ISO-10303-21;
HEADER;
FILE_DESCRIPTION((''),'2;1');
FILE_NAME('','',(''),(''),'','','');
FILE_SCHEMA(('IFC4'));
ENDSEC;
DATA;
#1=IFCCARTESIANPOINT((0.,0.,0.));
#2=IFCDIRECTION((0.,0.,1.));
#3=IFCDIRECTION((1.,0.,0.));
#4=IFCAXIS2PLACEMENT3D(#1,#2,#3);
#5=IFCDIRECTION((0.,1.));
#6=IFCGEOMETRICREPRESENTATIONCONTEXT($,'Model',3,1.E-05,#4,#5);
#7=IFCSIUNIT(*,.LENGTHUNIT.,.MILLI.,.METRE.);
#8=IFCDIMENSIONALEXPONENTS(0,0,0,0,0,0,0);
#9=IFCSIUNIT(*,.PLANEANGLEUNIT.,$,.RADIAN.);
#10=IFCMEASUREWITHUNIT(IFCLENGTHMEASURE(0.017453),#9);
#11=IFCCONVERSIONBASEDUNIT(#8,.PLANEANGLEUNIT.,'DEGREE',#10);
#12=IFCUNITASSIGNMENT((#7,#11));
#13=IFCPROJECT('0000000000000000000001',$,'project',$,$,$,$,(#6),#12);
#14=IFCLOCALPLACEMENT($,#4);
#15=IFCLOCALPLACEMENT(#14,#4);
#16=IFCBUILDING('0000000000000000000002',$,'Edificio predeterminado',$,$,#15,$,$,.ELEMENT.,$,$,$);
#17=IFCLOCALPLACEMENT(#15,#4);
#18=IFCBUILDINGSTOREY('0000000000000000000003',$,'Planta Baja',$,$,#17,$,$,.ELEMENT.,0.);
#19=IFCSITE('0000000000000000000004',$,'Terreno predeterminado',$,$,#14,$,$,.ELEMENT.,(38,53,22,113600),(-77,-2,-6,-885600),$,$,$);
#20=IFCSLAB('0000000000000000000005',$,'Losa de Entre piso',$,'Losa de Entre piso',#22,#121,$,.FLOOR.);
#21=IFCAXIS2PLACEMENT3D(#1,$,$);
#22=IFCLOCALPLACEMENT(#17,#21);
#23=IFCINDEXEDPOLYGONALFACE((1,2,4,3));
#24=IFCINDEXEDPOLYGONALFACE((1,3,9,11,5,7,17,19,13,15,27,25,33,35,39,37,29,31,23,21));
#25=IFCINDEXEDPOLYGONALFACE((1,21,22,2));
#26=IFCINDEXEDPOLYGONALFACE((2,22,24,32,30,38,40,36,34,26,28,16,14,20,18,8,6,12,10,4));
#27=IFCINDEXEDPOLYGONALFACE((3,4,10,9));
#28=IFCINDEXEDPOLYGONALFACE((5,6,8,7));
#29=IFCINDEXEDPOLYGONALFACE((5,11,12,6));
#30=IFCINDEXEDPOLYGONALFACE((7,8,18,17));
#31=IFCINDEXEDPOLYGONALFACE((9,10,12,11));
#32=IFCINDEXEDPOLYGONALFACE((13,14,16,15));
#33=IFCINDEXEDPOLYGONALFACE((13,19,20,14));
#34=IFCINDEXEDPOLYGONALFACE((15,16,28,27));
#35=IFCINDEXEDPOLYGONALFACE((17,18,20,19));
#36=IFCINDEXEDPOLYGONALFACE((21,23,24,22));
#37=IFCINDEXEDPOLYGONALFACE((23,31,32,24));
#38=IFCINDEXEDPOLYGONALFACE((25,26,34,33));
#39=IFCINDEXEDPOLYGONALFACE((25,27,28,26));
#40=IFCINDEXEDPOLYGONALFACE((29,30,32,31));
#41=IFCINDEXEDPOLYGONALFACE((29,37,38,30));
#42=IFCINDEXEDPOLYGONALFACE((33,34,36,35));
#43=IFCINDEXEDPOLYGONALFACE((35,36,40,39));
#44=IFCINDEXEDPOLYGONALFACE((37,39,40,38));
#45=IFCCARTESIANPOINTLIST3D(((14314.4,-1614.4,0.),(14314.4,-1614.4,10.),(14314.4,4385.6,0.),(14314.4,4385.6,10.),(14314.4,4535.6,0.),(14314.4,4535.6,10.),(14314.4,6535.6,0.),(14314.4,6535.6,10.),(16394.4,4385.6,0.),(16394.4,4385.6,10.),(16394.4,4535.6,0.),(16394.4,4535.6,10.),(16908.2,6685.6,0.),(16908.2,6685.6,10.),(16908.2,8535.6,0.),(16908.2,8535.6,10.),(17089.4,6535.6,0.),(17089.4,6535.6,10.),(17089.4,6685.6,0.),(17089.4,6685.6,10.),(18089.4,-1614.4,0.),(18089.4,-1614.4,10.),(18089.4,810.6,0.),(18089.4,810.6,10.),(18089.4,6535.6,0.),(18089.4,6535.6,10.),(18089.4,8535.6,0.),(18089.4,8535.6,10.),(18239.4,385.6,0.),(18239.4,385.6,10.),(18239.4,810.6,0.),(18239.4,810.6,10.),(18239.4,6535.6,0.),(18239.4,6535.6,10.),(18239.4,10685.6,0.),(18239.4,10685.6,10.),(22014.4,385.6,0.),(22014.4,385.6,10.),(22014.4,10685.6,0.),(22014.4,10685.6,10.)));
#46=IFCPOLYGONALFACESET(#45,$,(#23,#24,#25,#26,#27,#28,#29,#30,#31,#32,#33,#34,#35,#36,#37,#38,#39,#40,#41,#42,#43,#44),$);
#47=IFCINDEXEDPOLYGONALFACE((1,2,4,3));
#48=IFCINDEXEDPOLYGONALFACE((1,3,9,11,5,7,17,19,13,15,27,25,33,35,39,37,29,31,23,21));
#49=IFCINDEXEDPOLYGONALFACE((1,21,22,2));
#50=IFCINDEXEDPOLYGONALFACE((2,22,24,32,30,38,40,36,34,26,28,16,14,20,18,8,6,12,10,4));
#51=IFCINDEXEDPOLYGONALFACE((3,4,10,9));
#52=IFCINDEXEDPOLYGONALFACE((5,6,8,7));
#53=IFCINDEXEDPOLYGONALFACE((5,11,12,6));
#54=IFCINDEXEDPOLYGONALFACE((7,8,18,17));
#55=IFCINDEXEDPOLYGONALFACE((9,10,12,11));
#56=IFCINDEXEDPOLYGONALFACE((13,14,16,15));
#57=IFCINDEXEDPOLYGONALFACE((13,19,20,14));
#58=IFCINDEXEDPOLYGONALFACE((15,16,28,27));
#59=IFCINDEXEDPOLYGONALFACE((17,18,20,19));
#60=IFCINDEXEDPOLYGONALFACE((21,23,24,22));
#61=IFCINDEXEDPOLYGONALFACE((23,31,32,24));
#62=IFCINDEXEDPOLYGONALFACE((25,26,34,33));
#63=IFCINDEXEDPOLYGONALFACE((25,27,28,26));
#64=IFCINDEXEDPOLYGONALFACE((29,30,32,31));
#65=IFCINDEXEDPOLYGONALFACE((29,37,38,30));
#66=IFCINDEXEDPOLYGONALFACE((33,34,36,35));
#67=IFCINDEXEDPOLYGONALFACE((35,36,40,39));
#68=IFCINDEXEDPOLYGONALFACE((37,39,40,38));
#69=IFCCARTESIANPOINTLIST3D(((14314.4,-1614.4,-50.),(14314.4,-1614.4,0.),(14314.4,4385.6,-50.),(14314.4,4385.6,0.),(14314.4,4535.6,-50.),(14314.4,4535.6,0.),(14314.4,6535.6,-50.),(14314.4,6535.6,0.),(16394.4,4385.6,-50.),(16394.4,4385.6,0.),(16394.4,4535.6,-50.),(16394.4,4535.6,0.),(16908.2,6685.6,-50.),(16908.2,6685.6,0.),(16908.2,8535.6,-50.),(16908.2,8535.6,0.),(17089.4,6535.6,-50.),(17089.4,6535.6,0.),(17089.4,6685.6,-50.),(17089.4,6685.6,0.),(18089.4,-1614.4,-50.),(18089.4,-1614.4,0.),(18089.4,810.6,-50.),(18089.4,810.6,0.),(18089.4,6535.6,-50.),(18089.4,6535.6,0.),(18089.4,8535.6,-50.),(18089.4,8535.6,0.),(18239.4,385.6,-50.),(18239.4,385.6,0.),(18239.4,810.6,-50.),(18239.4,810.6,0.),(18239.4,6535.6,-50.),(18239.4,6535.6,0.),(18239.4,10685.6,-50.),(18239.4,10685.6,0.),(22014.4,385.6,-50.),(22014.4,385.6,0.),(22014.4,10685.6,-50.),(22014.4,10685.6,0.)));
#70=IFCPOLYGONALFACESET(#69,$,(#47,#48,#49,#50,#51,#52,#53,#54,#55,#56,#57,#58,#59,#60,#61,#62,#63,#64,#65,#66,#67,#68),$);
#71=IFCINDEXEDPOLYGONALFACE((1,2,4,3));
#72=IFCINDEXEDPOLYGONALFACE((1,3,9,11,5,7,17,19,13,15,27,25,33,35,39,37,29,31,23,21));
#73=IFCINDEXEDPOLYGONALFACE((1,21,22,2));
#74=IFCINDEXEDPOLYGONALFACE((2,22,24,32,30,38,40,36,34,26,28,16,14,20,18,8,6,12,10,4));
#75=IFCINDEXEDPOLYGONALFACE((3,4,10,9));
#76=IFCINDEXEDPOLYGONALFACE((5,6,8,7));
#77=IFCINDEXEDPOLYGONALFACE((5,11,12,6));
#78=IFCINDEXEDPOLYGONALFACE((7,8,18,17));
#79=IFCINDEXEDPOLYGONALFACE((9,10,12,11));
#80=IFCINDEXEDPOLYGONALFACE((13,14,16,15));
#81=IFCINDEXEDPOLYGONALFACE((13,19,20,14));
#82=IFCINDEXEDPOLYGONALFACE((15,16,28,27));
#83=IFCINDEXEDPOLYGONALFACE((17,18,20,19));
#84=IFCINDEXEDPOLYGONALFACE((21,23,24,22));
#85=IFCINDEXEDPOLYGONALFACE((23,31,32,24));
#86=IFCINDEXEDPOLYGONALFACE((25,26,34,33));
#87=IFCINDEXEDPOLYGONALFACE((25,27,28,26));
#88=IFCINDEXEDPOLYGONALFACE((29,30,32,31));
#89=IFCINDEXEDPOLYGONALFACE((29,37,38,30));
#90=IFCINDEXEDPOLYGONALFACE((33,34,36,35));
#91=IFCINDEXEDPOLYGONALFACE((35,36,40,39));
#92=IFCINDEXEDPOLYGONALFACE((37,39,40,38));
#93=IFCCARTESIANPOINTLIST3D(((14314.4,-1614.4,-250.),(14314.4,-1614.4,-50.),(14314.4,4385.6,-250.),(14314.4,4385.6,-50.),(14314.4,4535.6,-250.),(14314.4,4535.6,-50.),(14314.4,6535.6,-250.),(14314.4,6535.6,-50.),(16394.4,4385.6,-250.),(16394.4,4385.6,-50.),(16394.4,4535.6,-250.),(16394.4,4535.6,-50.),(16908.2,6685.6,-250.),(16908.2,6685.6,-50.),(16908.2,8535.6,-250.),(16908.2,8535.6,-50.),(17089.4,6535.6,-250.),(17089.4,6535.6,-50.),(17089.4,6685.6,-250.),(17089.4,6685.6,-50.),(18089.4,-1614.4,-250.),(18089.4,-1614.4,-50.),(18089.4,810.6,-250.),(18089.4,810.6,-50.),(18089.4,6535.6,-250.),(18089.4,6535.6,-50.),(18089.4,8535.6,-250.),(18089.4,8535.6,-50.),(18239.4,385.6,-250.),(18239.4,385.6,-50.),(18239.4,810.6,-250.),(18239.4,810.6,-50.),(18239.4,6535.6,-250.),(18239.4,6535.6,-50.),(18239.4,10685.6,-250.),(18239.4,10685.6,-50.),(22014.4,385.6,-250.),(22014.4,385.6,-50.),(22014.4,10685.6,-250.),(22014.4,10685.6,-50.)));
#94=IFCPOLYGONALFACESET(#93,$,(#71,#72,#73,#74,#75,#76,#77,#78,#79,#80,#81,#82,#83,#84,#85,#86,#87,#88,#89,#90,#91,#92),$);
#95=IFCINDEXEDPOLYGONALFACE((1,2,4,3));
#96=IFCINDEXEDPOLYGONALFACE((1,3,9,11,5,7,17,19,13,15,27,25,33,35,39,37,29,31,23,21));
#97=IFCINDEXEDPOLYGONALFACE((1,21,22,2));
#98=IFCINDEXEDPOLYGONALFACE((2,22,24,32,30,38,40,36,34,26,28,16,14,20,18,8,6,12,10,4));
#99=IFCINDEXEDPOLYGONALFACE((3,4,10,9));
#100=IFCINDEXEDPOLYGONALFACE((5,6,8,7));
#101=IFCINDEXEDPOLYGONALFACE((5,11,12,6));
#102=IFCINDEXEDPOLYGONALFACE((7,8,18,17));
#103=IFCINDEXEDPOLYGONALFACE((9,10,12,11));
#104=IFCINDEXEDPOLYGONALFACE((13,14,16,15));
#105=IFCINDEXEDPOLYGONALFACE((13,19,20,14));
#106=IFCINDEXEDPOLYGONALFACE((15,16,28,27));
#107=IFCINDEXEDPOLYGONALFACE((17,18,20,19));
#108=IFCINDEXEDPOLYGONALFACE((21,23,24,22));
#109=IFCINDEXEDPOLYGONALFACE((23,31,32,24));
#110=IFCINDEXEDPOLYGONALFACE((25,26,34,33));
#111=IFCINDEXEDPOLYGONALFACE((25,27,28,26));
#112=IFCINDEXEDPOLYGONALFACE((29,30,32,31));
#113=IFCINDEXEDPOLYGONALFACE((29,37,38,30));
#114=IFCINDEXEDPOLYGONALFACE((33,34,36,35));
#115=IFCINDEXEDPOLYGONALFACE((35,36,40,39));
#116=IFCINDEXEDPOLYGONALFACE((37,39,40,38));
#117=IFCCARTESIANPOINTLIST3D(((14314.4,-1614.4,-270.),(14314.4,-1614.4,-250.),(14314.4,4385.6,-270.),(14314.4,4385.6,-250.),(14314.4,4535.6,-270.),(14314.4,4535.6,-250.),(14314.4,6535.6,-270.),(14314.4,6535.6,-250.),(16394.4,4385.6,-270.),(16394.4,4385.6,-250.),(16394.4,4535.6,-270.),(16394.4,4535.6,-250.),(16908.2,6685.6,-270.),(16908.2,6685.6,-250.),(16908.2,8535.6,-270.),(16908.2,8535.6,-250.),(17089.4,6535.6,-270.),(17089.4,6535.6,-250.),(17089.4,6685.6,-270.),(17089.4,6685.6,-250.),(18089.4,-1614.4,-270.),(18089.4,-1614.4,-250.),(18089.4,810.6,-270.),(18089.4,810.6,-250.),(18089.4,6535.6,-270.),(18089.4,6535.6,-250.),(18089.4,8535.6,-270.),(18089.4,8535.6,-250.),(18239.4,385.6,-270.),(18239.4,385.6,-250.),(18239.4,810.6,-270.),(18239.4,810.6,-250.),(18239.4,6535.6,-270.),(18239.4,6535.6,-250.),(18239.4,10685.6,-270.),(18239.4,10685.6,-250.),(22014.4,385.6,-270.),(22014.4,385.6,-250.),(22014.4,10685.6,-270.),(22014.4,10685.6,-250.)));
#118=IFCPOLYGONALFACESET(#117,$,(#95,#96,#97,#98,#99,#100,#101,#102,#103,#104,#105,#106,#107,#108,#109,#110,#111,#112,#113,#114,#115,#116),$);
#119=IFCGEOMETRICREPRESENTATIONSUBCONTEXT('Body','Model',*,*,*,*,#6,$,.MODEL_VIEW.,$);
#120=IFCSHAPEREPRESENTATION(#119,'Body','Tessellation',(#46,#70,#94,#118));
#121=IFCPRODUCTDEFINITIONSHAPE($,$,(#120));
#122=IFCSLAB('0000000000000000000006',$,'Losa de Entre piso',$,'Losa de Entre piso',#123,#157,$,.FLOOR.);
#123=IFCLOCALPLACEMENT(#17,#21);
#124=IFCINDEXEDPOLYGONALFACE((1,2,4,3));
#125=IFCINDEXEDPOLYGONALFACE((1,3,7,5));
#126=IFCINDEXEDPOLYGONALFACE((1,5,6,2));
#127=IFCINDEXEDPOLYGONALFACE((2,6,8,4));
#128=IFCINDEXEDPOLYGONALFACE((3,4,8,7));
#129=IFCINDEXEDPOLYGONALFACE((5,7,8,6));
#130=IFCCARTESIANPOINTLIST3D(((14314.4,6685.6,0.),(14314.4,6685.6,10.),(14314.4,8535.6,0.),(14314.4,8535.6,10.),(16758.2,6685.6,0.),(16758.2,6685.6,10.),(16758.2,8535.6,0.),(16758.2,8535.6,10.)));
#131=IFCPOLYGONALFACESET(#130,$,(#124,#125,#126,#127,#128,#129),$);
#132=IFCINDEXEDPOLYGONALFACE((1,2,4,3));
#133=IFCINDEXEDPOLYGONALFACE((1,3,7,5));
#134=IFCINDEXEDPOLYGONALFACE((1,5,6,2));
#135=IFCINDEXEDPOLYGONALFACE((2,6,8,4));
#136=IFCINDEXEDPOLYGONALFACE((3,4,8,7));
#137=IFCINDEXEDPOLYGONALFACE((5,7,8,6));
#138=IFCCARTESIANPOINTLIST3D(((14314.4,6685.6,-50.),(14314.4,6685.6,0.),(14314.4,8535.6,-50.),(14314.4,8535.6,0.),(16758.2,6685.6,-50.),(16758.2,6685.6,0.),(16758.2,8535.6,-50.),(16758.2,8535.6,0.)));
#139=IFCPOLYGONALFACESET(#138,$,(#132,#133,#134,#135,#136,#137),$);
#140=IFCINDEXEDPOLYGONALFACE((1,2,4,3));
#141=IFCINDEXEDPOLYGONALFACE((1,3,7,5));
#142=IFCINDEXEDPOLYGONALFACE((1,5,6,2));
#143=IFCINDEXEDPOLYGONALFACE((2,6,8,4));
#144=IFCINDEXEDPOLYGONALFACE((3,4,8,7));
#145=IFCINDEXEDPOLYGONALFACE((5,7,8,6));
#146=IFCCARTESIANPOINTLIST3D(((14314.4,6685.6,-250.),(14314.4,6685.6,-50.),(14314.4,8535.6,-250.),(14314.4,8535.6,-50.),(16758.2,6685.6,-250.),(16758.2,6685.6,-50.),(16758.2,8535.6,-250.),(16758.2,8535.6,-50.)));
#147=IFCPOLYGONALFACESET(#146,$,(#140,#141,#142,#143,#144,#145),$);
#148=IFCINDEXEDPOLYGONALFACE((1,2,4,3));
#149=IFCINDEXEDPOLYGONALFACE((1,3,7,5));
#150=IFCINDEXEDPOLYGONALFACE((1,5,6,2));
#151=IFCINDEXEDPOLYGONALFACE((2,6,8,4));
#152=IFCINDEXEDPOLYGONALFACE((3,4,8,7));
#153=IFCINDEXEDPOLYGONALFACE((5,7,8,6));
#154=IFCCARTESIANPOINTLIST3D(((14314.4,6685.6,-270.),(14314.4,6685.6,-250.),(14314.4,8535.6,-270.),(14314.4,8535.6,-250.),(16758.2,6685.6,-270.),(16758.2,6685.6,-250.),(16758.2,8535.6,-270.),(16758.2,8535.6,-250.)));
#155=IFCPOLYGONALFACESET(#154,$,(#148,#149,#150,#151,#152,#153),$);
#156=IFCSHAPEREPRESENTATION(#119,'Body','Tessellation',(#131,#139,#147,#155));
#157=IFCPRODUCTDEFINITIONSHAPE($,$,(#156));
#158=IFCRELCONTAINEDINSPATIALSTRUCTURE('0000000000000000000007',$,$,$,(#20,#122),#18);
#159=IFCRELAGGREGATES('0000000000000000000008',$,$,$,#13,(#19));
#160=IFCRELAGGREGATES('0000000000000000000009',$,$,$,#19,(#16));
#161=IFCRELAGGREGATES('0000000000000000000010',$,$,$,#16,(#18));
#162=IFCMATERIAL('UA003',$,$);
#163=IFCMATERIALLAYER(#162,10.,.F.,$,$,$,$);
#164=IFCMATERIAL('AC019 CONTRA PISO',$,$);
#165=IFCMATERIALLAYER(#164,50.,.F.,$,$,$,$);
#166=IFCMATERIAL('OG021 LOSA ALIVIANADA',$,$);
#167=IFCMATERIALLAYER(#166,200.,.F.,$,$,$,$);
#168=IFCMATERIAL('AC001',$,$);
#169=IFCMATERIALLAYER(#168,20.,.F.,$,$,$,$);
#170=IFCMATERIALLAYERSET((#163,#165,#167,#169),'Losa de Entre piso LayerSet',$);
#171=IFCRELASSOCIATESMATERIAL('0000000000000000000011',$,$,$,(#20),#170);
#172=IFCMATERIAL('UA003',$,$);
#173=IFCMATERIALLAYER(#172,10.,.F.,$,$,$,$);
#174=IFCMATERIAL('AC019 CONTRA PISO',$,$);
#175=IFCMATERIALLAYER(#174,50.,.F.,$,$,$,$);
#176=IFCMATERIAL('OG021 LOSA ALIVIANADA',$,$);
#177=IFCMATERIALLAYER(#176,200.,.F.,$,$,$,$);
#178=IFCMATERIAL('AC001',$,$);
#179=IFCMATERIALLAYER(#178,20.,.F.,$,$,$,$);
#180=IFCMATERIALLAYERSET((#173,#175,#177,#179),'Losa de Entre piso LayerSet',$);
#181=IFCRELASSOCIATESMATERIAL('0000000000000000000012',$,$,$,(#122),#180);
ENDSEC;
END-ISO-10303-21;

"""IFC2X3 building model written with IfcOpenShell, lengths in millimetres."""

from ifc_helpers import new_model, entity, si_unit, converted_unit, direction, frame, origin_with_axes, place, context, subcontext, project, spatial, polyline, outline, extrude, material, layer, layer_set, layer_usage, element, save


model = new_model("IFC2X3")

# Units and contexts
model_context = context("Model", 3, precision=1e-05, world=origin_with_axes(), true_north=direction((0.0, 1.0)))
body_context = subcontext(model_context, "Body", "Model", "MODEL_VIEW")
ifc_project = project(units=[si_unit("LENGTHUNIT", "METRE", prefix="MILLI"), converted_unit("PLANEANGLEUNIT", "DEGREE", entity("IfcLengthMeasure", 0.017453), si_unit("PLANEANGLEUNIT", "RADIAN"), dimensions=[0, 0, 0, 0, 0, 0, 0])], contexts=[model_context])

# Site, building, storey
site_placement = place(None, origin_with_axes())
site = spatial("IfcSite", under=ifc_project, at=site_placement, Name="Terreno predeterminado", CompositionType="ELEMENT", RefLatitude=(38, 53, 22, 113600), RefLongitude=(-77, -2, -6, -885600))
building_placement = place(site_placement, origin_with_axes())
building = spatial("IfcBuilding", under=site, at=building_placement, Name="Edificio predeterminado", CompositionType="ELEMENT")
storey_placement = place(building_placement, origin_with_axes())
storey = spatial("IfcBuildingStorey", under=building, at=storey_placement, Name="Planta Baja", CompositionType="ELEMENT", Elevation=0.0)

# Slabs
ifc_material_1 = material(Name="UA003")
ifc_layer_1 = layer(ifc_material_1, 10.0, ventilated=False)
ifc_material_2 = material(Name="AC019 CONTRA PISO")
ifc_layer_2 = layer(ifc_material_2, 50.0, ventilated=False)
ifc_material_3 = material(Name="OG021 LOSA ALIVIANADA")
ifc_layer_3 = layer(ifc_material_3, 200.0, ventilated=False)
ifc_material_4 = material(Name="AC001")
ifc_layer_4 = layer(ifc_material_4, 20.0, ventilated=False)
ifc_layer_set_1 = layer_set([ifc_layer_1, ifc_layer_2, ifc_layer_3, ifc_layer_4], Name="Losa de Entre piso LayerSet")
ifc_layer_usage_1 = layer_usage(ifc_layer_set_1, "AXIS3", "POSITIVE", 0.0)
slab_1_placement = place(storey_placement, origin_with_axes())
element("IfcSlab", 1, at=slab_1_placement, inside=storey, material=ifc_layer_usage_1, Name="Losa de Entre piso", ObjectType="Losa de Entre piso", PredefinedType="FLOOR", context=body_context, shape_type="SweptSolid", body=[
    extrude(outline(polyline([(0.0, -6000.0), (3775.0, -6000.0), (3775.0, -3575.0), (3925.0, -3575.0), (3925.0, -4000.0), (7700.0, -4000.0), (7700.0, 6300.0), (3925.0, 6300.0), (3925.0, 2150.0), (3775.0, 2150.0), (3775.0, 4150.0), (2593.9, 4150.0), (2593.9, 2300.0), (2775.0, 2300.0), (2775.0, 2150.0), (0.0, 2150.0), (0.0, 150.0), (2080.0, 150.0), (2080.0, 0.0), (0.0, 0.0), (0.0, -6000.0)])), frame((14314.4, 4385.6, 0.0), z_axis=(0.0, 0.0, 1.0), x_axis=(1.0, 0.0, 0.0)), (0.0, 0.0, 1.0), 10.0),
    extrude(outline(polyline([(0.0, -6000.0), (3775.0, -6000.0), (3775.0, -3575.0), (3925.0, -3575.0), (3925.0, -4000.0), (7700.0, -4000.0), (7700.0, 6300.0), (3925.0, 6300.0), (3925.0, 2150.0), (3775.0, 2150.0), (3775.0, 4150.0), (2593.9, 4150.0), (2593.9, 2300.0), (2775.0, 2300.0), (2775.0, 2150.0), (0.0, 2150.0), (0.0, 150.0), (2080.0, 150.0), (2080.0, 0.0), (0.0, 0.0), (0.0, -6000.0)])), frame((14314.4, 4385.6, -50.0), z_axis=(0.0, 0.0, 1.0), x_axis=(1.0, 0.0, 0.0)), (0.0, 0.0, 1.0), 50.0),
    extrude(outline(polyline([(0.0, -6000.0), (3775.0, -6000.0), (3775.0, -3575.0), (3925.0, -3575.0), (3925.0, -4000.0), (7700.0, -4000.0), (7700.0, 6300.0), (3925.0, 6300.0), (3925.0, 2150.0), (3775.0, 2150.0), (3775.0, 4150.0), (2593.9, 4150.0), (2593.9, 2300.0), (2775.0, 2300.0), (2775.0, 2150.0), (0.0, 2150.0), (0.0, 150.0), (2080.0, 150.0), (2080.0, 0.0), (0.0, 0.0), (0.0, -6000.0)])), frame((14314.4, 4385.6, -250.0), z_axis=(0.0, 0.0, 1.0), x_axis=(1.0, 0.0, 0.0)), (0.0, 0.0, 1.0), 200.0),
    extrude(outline(polyline([(0.0, -6000.0), (3775.0, -6000.0), (3775.0, -3575.0), (3925.0, -3575.0), (3925.0, -4000.0), (7700.0, -4000.0), (7700.0, 6300.0), (3925.0, 6300.0), (3925.0, 2150.0), (3775.0, 2150.0), (3775.0, 4150.0), (2593.9, 4150.0), (2593.9, 2300.0), (2775.0, 2300.0), (2775.0, 2150.0), (0.0, 2150.0), (0.0, 150.0), (2080.0, 150.0), (2080.0, 0.0), (0.0, 0.0), (0.0, -6000.0)])), frame((14314.4, 4385.6, -270.0), z_axis=(0.0, 0.0, 1.0), x_axis=(1.0, 0.0, 0.0)), (0.0, 0.0, 1.0), 20.0),
])
ifc_material_5 = material(Name="UA003")
ifc_layer_5 = layer(ifc_material_5, 10.0, ventilated=False)
ifc_material_6 = material(Name="AC019 CONTRA PISO")
ifc_layer_6 = layer(ifc_material_6, 50.0, ventilated=False)
ifc_material_7 = material(Name="OG021 LOSA ALIVIANADA")
ifc_layer_7 = layer(ifc_material_7, 200.0, ventilated=False)
ifc_material_8 = material(Name="AC001")
ifc_layer_8 = layer(ifc_material_8, 20.0, ventilated=False)
ifc_layer_set_2 = layer_set([ifc_layer_5, ifc_layer_6, ifc_layer_7, ifc_layer_8], Name="Losa de Entre piso LayerSet")
ifc_layer_usage_2 = layer_usage(ifc_layer_set_2, "AXIS3", "NEGATIVE", 0.0)
slab_2_placement = place(storey_placement, origin_with_axes())
element("IfcSlab", 2, at=slab_2_placement, inside=storey, material=ifc_layer_usage_2, Name="Losa de Entre piso", ObjectType="Losa de Entre piso", PredefinedType="FLOOR", context=body_context, shape_type="SweptSolid", body=[
    extrude(outline(polyline([(0.0, 2443.9), (1850.0, 2443.9), (1850.0, 0.0), (0.0, 0.0), (0.0, 2443.9)])), frame((14314.4, 6685.6, 0.0), z_axis=(0.0, 0.0, -1.0), x_axis=(0.0, 1.0, 0.0)), (0.0, 0.0, -1.0), 10.0),
    extrude(outline(polyline([(0.0, 2443.9), (1850.0, 2443.9), (1850.0, 0.0), (0.0, 0.0), (0.0, 2443.9)])), frame((14314.4, 6685.6, -50.0), z_axis=(0.0, 0.0, -1.0), x_axis=(0.0, 1.0, 0.0)), (0.0, 0.0, -1.0), 50.0),
    extrude(outline(polyline([(0.0, 2443.9), (1850.0, 2443.9), (1850.0, 0.0), (0.0, 0.0), (0.0, 2443.9)])), frame((14314.4, 6685.6, -250.0), z_axis=(0.0, 0.0, -1.0), x_axis=(0.0, 1.0, 0.0)), (0.0, 0.0, -1.0), 200.0),
    extrude(outline(polyline([(0.0, 2443.9), (1850.0, 2443.9), (1850.0, 0.0), (0.0, 0.0), (0.0, 2443.9)])), frame((14314.4, 6685.6, -270.0), z_axis=(0.0, 0.0, -1.0), x_axis=(0.0, 1.0, 0.0)), (0.0, 0.0, -1.0), 20.0),
])

save(model, "model.ifc")
